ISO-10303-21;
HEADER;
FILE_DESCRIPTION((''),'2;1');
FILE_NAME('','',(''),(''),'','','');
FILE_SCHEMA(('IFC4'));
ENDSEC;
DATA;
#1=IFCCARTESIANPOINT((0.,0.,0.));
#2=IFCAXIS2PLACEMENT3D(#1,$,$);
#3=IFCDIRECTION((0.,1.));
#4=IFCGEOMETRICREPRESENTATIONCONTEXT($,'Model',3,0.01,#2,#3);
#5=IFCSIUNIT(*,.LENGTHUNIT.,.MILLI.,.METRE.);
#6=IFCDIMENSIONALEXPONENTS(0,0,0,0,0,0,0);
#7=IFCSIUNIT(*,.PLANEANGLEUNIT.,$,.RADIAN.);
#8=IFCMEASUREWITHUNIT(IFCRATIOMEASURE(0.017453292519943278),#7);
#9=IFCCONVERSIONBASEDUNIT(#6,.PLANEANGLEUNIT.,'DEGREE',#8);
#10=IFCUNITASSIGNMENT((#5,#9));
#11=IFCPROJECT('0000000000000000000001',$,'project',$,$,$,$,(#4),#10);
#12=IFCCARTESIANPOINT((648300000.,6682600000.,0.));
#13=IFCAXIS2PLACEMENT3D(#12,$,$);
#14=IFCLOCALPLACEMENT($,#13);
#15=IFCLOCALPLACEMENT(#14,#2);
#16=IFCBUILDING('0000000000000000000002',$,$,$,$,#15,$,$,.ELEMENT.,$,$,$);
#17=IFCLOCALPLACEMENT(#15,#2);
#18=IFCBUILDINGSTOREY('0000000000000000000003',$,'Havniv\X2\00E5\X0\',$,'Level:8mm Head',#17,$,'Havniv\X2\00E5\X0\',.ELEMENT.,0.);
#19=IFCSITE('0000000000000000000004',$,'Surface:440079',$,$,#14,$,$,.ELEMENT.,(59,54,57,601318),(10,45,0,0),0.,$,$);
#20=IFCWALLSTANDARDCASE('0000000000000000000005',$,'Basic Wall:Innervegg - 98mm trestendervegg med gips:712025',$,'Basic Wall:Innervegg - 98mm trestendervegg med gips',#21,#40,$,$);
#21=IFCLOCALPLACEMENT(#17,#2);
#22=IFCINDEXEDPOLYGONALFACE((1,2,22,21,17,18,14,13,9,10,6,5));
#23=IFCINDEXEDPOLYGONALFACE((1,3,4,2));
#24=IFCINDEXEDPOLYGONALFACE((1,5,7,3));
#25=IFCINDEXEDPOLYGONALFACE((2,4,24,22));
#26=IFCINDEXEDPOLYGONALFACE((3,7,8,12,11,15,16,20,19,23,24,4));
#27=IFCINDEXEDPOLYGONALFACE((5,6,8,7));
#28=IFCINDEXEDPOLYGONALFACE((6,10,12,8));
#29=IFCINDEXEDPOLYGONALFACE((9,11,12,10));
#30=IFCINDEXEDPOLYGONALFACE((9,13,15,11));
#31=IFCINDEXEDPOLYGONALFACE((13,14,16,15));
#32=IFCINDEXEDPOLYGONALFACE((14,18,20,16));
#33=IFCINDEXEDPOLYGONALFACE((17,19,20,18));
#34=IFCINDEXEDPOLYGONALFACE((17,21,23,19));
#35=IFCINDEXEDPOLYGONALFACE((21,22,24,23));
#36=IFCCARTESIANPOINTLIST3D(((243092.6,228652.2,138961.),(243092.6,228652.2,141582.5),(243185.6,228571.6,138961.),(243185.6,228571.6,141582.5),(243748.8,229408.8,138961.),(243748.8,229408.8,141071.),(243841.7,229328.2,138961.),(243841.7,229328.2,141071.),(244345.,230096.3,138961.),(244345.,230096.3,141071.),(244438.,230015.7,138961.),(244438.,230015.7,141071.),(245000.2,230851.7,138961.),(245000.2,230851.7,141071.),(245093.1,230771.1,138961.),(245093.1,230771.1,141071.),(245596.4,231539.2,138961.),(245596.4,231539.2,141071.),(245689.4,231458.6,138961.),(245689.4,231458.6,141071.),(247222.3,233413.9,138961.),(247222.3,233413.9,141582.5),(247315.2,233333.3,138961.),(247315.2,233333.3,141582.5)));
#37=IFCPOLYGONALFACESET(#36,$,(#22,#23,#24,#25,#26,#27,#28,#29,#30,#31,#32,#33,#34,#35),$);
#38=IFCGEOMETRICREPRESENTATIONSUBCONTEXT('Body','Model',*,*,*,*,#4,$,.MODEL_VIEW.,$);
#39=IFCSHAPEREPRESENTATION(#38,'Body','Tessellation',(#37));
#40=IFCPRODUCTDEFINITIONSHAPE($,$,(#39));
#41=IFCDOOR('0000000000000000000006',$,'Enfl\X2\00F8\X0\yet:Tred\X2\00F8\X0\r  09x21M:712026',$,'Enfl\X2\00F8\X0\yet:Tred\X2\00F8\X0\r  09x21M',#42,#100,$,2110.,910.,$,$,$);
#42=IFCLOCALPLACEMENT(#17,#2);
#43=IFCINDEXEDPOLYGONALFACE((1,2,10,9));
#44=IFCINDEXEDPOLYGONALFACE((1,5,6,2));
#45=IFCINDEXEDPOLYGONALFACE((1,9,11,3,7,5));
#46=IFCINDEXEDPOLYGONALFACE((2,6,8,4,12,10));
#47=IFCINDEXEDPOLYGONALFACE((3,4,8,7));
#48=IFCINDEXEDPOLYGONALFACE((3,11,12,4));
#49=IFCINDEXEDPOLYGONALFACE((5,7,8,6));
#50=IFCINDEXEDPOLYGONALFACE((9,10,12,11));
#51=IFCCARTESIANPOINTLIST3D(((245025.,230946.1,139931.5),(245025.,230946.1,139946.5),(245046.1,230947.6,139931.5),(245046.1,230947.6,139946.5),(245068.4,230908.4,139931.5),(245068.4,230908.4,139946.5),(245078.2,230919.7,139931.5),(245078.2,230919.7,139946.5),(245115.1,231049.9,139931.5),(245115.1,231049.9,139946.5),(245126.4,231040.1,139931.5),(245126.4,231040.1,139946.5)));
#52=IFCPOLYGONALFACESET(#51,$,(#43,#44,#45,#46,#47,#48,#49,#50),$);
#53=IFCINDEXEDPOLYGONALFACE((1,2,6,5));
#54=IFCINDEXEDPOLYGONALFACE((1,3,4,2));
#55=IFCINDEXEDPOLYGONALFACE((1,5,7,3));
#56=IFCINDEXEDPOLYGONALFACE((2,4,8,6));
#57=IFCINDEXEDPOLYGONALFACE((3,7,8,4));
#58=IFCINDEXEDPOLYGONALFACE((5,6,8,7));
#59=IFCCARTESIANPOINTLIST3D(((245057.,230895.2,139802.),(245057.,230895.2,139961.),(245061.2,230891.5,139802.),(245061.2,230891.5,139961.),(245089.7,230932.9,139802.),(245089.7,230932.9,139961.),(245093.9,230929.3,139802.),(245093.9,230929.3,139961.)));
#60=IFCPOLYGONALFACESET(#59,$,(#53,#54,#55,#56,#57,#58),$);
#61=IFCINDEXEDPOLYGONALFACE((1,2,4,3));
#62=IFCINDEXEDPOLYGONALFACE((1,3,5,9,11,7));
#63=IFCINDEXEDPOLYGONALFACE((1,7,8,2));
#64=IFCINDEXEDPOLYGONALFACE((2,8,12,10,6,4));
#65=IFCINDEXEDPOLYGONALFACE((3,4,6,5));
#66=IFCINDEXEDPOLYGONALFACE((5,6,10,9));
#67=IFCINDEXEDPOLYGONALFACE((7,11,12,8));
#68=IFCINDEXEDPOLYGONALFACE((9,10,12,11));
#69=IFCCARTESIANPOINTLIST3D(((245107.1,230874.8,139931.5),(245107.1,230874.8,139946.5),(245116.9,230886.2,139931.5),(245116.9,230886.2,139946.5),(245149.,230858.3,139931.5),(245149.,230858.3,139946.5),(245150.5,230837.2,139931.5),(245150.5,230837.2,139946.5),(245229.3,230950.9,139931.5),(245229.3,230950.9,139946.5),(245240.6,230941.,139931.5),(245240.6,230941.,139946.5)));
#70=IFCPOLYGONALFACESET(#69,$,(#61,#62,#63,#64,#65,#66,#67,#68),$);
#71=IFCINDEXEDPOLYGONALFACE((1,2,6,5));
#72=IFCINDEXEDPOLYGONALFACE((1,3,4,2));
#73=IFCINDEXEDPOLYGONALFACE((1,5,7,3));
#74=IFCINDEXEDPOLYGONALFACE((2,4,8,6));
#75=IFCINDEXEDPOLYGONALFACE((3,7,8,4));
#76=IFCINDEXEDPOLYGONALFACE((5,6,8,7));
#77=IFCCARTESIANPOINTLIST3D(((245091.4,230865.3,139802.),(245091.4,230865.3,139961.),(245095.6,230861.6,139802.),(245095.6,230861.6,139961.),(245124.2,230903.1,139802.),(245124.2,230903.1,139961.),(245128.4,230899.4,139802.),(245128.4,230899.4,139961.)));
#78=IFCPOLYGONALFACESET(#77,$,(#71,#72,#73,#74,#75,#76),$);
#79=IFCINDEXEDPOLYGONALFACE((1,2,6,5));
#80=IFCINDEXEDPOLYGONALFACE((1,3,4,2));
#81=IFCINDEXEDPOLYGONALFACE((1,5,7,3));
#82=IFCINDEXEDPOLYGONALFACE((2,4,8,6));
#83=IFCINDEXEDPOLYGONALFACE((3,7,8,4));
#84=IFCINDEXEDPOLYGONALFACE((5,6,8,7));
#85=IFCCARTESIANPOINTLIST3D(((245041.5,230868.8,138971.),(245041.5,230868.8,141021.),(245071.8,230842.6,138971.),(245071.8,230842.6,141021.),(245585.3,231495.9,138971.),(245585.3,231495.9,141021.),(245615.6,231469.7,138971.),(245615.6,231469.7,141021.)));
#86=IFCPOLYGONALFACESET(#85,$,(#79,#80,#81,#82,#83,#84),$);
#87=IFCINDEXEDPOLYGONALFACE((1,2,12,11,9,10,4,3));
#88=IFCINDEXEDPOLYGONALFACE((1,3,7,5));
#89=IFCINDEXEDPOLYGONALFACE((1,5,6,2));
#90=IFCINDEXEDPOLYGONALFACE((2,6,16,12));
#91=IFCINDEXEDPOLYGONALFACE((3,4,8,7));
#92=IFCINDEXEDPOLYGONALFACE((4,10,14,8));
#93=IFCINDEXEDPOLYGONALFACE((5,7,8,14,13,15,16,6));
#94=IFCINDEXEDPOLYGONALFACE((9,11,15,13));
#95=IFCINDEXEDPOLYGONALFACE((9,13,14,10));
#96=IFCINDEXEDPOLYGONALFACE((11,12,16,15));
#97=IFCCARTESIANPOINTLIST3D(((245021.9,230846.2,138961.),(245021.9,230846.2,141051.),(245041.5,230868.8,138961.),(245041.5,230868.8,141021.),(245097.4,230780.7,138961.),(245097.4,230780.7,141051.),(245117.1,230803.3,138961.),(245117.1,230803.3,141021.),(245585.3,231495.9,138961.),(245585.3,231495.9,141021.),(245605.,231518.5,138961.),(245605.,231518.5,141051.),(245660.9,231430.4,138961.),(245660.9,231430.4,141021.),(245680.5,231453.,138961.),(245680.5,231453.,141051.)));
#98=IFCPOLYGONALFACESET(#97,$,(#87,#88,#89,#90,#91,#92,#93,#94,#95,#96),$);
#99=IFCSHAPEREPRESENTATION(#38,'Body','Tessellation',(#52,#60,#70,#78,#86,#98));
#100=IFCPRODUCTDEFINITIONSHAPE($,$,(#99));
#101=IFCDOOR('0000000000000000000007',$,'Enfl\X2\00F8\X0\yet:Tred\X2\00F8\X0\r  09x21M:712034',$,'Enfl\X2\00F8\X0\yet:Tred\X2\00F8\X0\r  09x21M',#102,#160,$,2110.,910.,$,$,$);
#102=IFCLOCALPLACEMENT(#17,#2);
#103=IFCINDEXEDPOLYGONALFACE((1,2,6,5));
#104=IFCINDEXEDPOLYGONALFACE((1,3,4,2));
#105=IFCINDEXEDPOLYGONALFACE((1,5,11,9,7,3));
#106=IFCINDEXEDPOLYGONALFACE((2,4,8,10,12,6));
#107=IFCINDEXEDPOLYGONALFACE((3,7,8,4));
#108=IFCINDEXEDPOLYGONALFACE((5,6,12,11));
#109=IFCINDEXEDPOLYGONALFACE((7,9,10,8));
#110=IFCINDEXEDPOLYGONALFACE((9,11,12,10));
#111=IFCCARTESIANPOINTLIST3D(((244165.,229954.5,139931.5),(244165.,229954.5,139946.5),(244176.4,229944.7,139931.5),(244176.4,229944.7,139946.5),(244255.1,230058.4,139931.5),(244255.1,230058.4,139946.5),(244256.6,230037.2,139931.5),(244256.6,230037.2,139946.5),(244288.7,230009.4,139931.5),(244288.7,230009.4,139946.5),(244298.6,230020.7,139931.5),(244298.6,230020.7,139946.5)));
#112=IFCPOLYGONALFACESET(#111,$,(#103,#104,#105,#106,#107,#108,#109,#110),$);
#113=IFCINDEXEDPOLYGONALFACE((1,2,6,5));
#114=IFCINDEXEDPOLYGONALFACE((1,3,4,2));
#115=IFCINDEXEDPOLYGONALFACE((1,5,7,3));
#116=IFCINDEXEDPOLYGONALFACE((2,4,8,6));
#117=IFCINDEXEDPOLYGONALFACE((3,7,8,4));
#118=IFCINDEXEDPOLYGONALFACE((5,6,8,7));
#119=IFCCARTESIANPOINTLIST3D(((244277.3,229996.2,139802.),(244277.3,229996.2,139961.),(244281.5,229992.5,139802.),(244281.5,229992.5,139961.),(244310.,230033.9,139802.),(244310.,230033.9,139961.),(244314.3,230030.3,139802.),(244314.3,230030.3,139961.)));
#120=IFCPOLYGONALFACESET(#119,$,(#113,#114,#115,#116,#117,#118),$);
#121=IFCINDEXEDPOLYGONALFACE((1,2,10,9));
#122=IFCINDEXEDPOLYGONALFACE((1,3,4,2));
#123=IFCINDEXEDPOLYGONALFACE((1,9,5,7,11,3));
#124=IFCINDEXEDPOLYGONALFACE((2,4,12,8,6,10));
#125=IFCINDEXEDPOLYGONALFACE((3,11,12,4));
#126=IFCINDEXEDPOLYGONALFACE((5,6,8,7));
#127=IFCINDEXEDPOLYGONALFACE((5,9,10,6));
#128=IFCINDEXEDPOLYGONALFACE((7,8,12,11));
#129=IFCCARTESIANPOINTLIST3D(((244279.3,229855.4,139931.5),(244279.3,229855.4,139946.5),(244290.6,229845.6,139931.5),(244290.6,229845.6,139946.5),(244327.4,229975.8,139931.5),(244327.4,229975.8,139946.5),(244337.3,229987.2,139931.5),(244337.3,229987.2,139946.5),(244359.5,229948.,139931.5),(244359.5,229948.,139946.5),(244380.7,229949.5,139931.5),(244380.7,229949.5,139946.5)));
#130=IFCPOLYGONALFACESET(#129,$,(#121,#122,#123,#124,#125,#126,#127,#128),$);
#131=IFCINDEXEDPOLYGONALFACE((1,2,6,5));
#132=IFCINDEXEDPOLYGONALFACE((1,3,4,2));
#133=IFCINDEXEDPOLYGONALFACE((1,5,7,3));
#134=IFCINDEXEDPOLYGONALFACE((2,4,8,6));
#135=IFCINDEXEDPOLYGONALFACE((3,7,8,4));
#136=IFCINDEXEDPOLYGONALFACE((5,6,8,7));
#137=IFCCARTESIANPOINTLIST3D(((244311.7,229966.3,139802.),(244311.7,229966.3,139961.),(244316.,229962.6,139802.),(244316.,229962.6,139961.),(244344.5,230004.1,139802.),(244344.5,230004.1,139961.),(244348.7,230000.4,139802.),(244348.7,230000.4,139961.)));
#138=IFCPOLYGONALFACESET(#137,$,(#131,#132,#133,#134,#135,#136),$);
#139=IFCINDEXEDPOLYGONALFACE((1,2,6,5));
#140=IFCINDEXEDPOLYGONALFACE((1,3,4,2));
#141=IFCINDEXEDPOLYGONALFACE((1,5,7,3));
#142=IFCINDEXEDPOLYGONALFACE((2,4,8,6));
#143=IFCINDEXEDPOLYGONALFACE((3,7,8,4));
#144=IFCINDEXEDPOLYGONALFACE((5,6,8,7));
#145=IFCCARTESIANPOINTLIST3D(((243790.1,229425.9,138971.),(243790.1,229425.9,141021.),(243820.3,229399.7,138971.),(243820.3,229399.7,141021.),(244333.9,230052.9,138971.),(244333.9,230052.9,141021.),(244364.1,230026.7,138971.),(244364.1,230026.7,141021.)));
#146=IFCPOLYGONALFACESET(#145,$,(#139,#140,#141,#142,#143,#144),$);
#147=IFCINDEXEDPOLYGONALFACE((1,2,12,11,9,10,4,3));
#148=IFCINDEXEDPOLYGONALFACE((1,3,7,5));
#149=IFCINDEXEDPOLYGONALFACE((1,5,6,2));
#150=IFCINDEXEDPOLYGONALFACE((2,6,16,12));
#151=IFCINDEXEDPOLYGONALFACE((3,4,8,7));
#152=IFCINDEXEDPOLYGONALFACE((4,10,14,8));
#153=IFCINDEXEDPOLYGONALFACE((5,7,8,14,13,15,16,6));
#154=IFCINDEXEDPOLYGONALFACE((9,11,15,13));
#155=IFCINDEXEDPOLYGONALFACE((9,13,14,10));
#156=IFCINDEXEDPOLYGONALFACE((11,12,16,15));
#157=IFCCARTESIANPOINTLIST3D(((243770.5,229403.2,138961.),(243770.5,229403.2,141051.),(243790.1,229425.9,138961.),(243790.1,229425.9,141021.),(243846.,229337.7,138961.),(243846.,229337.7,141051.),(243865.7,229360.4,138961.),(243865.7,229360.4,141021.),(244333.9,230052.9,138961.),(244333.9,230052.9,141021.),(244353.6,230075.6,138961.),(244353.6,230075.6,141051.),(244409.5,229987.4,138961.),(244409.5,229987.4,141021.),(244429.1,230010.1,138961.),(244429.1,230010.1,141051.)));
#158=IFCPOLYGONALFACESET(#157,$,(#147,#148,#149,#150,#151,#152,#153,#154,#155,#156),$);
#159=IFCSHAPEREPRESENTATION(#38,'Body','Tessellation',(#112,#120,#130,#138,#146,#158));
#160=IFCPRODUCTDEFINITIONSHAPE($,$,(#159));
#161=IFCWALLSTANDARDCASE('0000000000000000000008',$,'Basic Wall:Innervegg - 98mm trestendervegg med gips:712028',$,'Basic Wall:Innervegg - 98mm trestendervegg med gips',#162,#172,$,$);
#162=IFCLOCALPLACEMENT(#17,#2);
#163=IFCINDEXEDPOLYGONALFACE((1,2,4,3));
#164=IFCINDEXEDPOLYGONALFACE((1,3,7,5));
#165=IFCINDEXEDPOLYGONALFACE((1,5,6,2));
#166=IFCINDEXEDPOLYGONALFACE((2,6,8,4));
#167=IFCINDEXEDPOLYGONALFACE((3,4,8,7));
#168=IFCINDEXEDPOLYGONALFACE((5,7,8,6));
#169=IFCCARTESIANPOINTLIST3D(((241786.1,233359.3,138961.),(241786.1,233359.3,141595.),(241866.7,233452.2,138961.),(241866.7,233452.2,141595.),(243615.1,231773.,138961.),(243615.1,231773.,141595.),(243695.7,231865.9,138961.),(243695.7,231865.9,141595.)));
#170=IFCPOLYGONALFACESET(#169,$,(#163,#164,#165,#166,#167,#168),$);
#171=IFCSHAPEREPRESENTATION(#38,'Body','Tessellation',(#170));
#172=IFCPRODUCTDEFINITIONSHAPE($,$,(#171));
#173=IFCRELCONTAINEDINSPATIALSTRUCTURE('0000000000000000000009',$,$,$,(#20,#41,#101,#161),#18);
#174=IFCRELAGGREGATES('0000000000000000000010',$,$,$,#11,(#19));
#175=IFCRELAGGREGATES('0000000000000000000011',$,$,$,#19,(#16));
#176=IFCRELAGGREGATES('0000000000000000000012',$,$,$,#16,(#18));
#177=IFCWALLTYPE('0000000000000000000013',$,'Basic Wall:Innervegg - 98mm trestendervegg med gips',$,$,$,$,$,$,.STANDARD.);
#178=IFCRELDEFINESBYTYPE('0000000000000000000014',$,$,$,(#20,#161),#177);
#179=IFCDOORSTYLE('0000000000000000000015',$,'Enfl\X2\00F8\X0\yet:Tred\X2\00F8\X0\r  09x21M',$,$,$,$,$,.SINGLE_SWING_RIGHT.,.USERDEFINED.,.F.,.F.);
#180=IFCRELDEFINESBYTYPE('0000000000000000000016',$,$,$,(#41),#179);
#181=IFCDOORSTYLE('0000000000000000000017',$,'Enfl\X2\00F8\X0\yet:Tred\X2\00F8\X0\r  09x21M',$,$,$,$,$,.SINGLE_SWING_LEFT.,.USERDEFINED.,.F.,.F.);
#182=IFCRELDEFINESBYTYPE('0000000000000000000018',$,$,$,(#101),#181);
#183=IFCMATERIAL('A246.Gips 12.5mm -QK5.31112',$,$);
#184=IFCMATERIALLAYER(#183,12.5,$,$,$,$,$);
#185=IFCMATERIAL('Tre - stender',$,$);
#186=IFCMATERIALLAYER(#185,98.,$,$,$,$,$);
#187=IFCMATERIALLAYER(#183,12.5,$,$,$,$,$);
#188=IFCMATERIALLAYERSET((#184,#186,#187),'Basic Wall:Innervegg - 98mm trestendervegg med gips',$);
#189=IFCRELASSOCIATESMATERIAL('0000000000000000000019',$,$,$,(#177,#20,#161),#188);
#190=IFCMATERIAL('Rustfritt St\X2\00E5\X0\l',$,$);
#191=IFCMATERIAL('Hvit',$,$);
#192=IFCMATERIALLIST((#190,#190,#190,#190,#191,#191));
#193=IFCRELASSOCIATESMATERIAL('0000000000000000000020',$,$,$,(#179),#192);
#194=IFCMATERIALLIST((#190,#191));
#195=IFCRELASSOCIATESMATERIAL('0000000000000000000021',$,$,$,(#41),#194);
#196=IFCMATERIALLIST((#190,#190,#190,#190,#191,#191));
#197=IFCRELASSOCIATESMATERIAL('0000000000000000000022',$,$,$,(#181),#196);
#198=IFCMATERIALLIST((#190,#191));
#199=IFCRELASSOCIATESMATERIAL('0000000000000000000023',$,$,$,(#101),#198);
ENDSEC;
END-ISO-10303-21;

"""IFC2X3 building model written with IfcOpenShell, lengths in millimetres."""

from ifc_helpers import new_model, entity, si_unit, converted_unit, direction, frame, frame_2d, origin, origin_2d_with_axis, place, context, subcontext, project, spatial, polyline, rectangle, outline, extrude, source, transform, mapped, material, material_list, layer, layer_set, layer_usage, type_object, type_shapes, element, fill, save


model = new_model("IFC2X3")

# Units and contexts
model_context = context("Model", 3, precision=0.01, world=origin(), true_north=direction((0.0, 1.0)))
body_context = subcontext(model_context, "Body", "Model", "MODEL_VIEW")
ifc_project = project(units=[si_unit("LENGTHUNIT", "METRE", prefix="MILLI"), converted_unit("PLANEANGLEUNIT", "DEGREE", entity("IfcRatioMeasure", 0.017453292519943278), si_unit("PLANEANGLEUNIT", "RADIAN"), dimensions=[0, 0, 0, 0, 0, 0, 0])], contexts=[model_context])

# Site, building, storey
site_placement = place(None, frame((648300000.0, 6682600000.0, 0.0)))
site = spatial("IfcSite", under=ifc_project, at=site_placement, Name="Surface:440079", CompositionType="ELEMENT", RefLatitude=(59, 54, 57, 601318), RefLongitude=(10, 45, 0, 0), RefElevation=0.0)
building_placement = place(site_placement, origin())
building = spatial("IfcBuilding", under=site, at=building_placement, CompositionType="ELEMENT")
storey_placement = place(building_placement, origin())
storey = spatial("IfcBuildingStorey", under=building, at=storey_placement, Name="Havnivå", ObjectType="Level:8mm Head", LongName="Havnivå", CompositionType="ELEMENT", Elevation=0.0)

# Wall, openings, doors
ifc_material_1 = material(Name="A246.Gips 12.5mm -QK5.31112")
ifc_layer_1 = layer(ifc_material_1, 12.5)
ifc_material_2 = material(Name="Tre - stender")
ifc_layer_2 = layer(ifc_material_2, 98.0)
ifc_layer_3 = layer(ifc_material_1, 12.5)
ifc_layer_set_1 = layer_set([ifc_layer_1, ifc_layer_2, ifc_layer_3], Name="Basic Wall:Innervegg - 98mm trestendervegg med gips")
ifc_layer_usage_1 = layer_usage(ifc_layer_set_1, "AXIS2", "POSITIVE", -61.5)
wall_type_1 = type_object("IfcWallType", Name="Basic Wall:Innervegg - 98mm trestendervegg med gips", PredefinedType="STANDARD", material=ifc_layer_set_1)
wall_1_placement = place(storey_placement, frame((243139.1, 228611.9, 138961.0), z_axis=(0.0, 0.0, 1.0), x_axis=(0.655187, 0.755467, 0.0)))
wall_1 = element("IfcWallStandardCase", 1, at=wall_1_placement, inside=storey, type_object=wall_type_1, material=ifc_layer_usage_1, Name="Basic Wall:Innervegg - 98mm trestendervegg med gips:712025", ObjectType="Basic Wall:Innervegg - 98mm trestendervegg med gips", context=body_context, shape_type="SweptSolid", body=[
    extrude(rectangle(XDim=6303.0, YDim=123.0, at=frame_2d((3151.5, 0.0), x_axis=(1.0, 0.0))), origin(), (0.0, 0.0, 1.0), 2621.5),
])
opening_1_placement = place(wall_1_placement, frame((2911.5, -61.5, 0.0)))
opening_1 = element("IfcOpeningElement", 2, at=opening_1_placement, cuts=wall_1, ObjectType="Opening", context=body_context, shape_type="SweptSolid", body=[
    extrude(rectangle(XDim=2110.0, YDim=910.0, at=frame_2d((1055.0, 455.0), x_axis=(1.0, 0.0))), frame((0.0, 0.0, 0.0), z_axis=(0.0, 1.0, 0.0), x_axis=(0.0, 0.0, 1.0)), (0.0, 0.0, 1.0), 123.0),
])
opening_2_placement = place(wall_1_placement, frame((1001.5, -61.5, 0.0)))
opening_2 = element("IfcOpeningElement", 3, at=opening_2_placement, cuts=wall_1, ObjectType="Opening", context=body_context, shape_type="SweptSolid", body=[
    extrude(rectangle(XDim=2110.0, YDim=910.0, at=frame_2d((1055.0, 455.0), x_axis=(1.0, 0.0))), frame((0.0, 0.0, 0.0), z_axis=(0.0, 1.0, 0.0), x_axis=(0.0, 0.0, 1.0)), (0.0, 0.0, 1.0), 123.0),
])
ifc_material_3 = material(Name="Rustfritt Stål")
ifc_material_4 = material(Name="Hvit")
ifc_material_list_1 = material_list([ifc_material_3, ifc_material_4])
ifc_material_list_2 = material_list([ifc_material_3, ifc_material_3, ifc_material_3, ifc_material_3, ifc_material_4, ifc_material_4])
door_style_1 = type_object("IfcDoorStyle", Name="Enfløyet:Tredør  09x21M", ConstructionType="USERDEFINED", OperationType="SINGLE_SWING_RIGHT", ParameterTakesPrecedence=False, Sizeable=False, material=ifc_material_list_2)
shared_shape_1 = source(origin(), body_context, "Body", "SweptSolid", [
    extrude(outline(polyline([(-50.8, -33.3), (-35.8, -33.3), (-35.8, 9.2), (86.7, 9.2), (86.7, 24.2), (-50.8, 24.2), (-50.8, -33.3)])), frame((138.3, 141.9, 970.5)), (0.0, 0.0, 1.0), 15.0),
    extrude(rectangle(XDim=50.0, YDim=5.6, at=frame_2d((0.0, 0.0), x_axis=(1.0, 0.0))), frame((95.0, 105.8, 841.0), z_axis=(0.0, 0.0, 1.0), x_axis=(-1.0, 0.0, 0.0)), (0.0, 0.0, 1.0), 159.0),
    extrude(outline(polyline([(-33.3, -50.8), (24.2, -50.8), (24.2, 86.7), (9.2, 86.7), (9.2, -35.8), (-33.3, -35.8), (-33.3, -50.8)])), frame((138.3, 24.1, 970.5), z_axis=(0.0, 0.0, 1.0), x_axis=(0.0, -1.0, 0.0)), (0.0, 0.0, 1.0), 15.0),
    extrude(rectangle(XDim=5.6, YDim=50.0, at=frame_2d((0.0, 0.0), x_axis=(1.0, 0.0))), frame((95.0, 60.2, 841.0), z_axis=(0.0, 0.0, 1.0), x_axis=(0.0, 1.0, 0.0)), (0.0, 0.0, 1.0), 159.0),
    extrude(rectangle(XDim=40.0, YDim=830.0, at=origin_2d_with_axis()), frame((455.0, 83.0, 10.0), z_axis=(0.0, 0.0, 1.0), x_axis=(0.0, -1.0, 0.0)), (0.0, 0.0, 1.0), 2050.0),
    extrude(outline(polyline([(-1037.5, -445.0), (1052.5, -445.0), (1052.5, 445.0), (-1037.5, 445.0), (-1037.5, 415.0), (1022.5, 415.0), (1022.5, -415.0), (-1037.5, -415.0), (-1037.5, -445.0)])), frame((455.0, 3.0, 1037.5), z_axis=(0.0, 1.0, 0.0), x_axis=(0.0, 0.0, 1.0)), (0.0, 0.0, 1.0), 100.0),
])
type_shapes(door_style_1, [shared_shape_1])
door_1_placement = place(opening_1_placement, origin())
door_1 = element("IfcDoor", 4, at=door_1_placement, inside=storey, type_object=door_style_1, material=ifc_material_list_1, Name="Enfløyet:Tredør  09x21M:712026", ObjectType="Enfløyet:Tredør  09x21M", OverallHeight=2110.0, OverallWidth=910.0, context=body_context, shape_type="MappedRepresentation", body=[
    mapped(shared_shape_1, transform((0.0, 0.0, 0.0), scale=1.0)),
])
fill(opening_1, door_1)
ifc_material_list_3 = material_list([ifc_material_3, ifc_material_4])
ifc_material_list_4 = material_list([ifc_material_3, ifc_material_3, ifc_material_3, ifc_material_3, ifc_material_4, ifc_material_4])
door_style_2 = type_object("IfcDoorStyle", Name="Enfløyet:Tredør  09x21M", ConstructionType="USERDEFINED", OperationType="SINGLE_SWING_LEFT", ParameterTakesPrecedence=False, Sizeable=False, material=ifc_material_list_4)
shared_shape_2 = source(origin(), body_context, "Body", "SweptSolid", [
    extrude(outline(polyline([(-33.3, -50.8), (24.2, -50.8), (24.2, 86.7), (9.2, 86.7), (9.2, -35.8), (-33.3, -35.8), (-33.3, -50.8)])), frame((771.7, 121.9, 970.5), z_axis=(0.0, 0.0, 1.0), x_axis=(0.0, 1.0, 0.0)), (0.0, 0.0, 1.0), 15.0),
    extrude(rectangle(XDim=5.6, YDim=50.0, at=frame_2d((0.0, 0.0), x_axis=(1.0, 0.0))), frame((815.0, 85.8, 841.0), z_axis=(0.0, 0.0, 1.0), x_axis=(0.0, -1.0, 0.0)), (0.0, 0.0, 1.0), 159.0),
    extrude(outline(polyline([(-50.8, -33.3), (-35.8, -33.3), (-35.8, 9.2), (86.7, 9.2), (86.7, 24.2), (-50.8, 24.2), (-50.8, -33.3)])), frame((771.7, 4.1, 970.5), z_axis=(0.0, 0.0, 1.0), x_axis=(-1.0, 0.0, 0.0)), (0.0, 0.0, 1.0), 15.0),
    extrude(rectangle(XDim=50.0, YDim=5.6, at=frame_2d((0.0, 0.0), x_axis=(1.0, 0.0))), frame((815.0, 40.2, 841.0)), (0.0, 0.0, 1.0), 159.0),
    extrude(rectangle(XDim=830.0, YDim=40.0, at=origin_2d_with_axis()), frame((455.0, 63.0, 10.0), z_axis=(0.0, 0.0, 1.0), x_axis=(-1.0, 0.0, 0.0)), (0.0, 0.0, 1.0), 2050.0),
    extrude(outline(polyline([(415.0, -1037.5), (445.0, -1037.5), (445.0, 1052.5), (-445.0, 1052.5), (-445.0, -1037.5), (-415.0, -1037.5), (-415.0, 1022.5), (415.0, 1022.5), (415.0, -1037.5)])), frame((455.0, 83.0, 1037.5), z_axis=(0.0, -1.0, 0.0), x_axis=(1.0, 0.0, 0.0)), (0.0, 0.0, 1.0), 100.0),
])
type_shapes(door_style_2, [shared_shape_2])
door_2_placement = place(opening_2_placement, frame((0.0, 20.0, 0.0)))
door_2 = element("IfcDoor", 5, at=door_2_placement, inside=storey, type_object=door_style_2, material=ifc_material_list_3, Name="Enfløyet:Tredør  09x21M:712034", ObjectType="Enfløyet:Tredør  09x21M", OverallHeight=2110.0, OverallWidth=910.0, context=body_context, shape_type="MappedRepresentation", body=[
    mapped(shared_shape_2, transform((0.0, 0.0, 0.0), scale=1.0)),
])
fill(opening_2, door_2)

# Wall
ifc_layer_usage_2 = layer_usage(ifc_layer_set_1, "AXIS2", "NEGATIVE", 61.5)
wall_2_placement = place(storey_placement, frame((243655.4, 231819.5, 138961.0), z_axis=(0.0, 0.0, 1.0), x_axis=(-0.755467, 0.655187, 0.0)))
element("IfcWallStandardCase", 6, at=wall_2_placement, inside=storey, type_object=wall_type_1, material=ifc_layer_usage_2, Name="Basic Wall:Innervegg - 98mm trestendervegg med gips:712028", ObjectType="Basic Wall:Innervegg - 98mm trestendervegg med gips", context=body_context, shape_type="SweptSolid", body=[
    extrude(rectangle(XDim=2421.1, YDim=123.0, at=frame_2d((1210.5, 0.0), x_axis=(-1.0, 0.0))), origin(), (0.0, 0.0, 1.0), 2634.0),
])

save(model, "model.ifc")
